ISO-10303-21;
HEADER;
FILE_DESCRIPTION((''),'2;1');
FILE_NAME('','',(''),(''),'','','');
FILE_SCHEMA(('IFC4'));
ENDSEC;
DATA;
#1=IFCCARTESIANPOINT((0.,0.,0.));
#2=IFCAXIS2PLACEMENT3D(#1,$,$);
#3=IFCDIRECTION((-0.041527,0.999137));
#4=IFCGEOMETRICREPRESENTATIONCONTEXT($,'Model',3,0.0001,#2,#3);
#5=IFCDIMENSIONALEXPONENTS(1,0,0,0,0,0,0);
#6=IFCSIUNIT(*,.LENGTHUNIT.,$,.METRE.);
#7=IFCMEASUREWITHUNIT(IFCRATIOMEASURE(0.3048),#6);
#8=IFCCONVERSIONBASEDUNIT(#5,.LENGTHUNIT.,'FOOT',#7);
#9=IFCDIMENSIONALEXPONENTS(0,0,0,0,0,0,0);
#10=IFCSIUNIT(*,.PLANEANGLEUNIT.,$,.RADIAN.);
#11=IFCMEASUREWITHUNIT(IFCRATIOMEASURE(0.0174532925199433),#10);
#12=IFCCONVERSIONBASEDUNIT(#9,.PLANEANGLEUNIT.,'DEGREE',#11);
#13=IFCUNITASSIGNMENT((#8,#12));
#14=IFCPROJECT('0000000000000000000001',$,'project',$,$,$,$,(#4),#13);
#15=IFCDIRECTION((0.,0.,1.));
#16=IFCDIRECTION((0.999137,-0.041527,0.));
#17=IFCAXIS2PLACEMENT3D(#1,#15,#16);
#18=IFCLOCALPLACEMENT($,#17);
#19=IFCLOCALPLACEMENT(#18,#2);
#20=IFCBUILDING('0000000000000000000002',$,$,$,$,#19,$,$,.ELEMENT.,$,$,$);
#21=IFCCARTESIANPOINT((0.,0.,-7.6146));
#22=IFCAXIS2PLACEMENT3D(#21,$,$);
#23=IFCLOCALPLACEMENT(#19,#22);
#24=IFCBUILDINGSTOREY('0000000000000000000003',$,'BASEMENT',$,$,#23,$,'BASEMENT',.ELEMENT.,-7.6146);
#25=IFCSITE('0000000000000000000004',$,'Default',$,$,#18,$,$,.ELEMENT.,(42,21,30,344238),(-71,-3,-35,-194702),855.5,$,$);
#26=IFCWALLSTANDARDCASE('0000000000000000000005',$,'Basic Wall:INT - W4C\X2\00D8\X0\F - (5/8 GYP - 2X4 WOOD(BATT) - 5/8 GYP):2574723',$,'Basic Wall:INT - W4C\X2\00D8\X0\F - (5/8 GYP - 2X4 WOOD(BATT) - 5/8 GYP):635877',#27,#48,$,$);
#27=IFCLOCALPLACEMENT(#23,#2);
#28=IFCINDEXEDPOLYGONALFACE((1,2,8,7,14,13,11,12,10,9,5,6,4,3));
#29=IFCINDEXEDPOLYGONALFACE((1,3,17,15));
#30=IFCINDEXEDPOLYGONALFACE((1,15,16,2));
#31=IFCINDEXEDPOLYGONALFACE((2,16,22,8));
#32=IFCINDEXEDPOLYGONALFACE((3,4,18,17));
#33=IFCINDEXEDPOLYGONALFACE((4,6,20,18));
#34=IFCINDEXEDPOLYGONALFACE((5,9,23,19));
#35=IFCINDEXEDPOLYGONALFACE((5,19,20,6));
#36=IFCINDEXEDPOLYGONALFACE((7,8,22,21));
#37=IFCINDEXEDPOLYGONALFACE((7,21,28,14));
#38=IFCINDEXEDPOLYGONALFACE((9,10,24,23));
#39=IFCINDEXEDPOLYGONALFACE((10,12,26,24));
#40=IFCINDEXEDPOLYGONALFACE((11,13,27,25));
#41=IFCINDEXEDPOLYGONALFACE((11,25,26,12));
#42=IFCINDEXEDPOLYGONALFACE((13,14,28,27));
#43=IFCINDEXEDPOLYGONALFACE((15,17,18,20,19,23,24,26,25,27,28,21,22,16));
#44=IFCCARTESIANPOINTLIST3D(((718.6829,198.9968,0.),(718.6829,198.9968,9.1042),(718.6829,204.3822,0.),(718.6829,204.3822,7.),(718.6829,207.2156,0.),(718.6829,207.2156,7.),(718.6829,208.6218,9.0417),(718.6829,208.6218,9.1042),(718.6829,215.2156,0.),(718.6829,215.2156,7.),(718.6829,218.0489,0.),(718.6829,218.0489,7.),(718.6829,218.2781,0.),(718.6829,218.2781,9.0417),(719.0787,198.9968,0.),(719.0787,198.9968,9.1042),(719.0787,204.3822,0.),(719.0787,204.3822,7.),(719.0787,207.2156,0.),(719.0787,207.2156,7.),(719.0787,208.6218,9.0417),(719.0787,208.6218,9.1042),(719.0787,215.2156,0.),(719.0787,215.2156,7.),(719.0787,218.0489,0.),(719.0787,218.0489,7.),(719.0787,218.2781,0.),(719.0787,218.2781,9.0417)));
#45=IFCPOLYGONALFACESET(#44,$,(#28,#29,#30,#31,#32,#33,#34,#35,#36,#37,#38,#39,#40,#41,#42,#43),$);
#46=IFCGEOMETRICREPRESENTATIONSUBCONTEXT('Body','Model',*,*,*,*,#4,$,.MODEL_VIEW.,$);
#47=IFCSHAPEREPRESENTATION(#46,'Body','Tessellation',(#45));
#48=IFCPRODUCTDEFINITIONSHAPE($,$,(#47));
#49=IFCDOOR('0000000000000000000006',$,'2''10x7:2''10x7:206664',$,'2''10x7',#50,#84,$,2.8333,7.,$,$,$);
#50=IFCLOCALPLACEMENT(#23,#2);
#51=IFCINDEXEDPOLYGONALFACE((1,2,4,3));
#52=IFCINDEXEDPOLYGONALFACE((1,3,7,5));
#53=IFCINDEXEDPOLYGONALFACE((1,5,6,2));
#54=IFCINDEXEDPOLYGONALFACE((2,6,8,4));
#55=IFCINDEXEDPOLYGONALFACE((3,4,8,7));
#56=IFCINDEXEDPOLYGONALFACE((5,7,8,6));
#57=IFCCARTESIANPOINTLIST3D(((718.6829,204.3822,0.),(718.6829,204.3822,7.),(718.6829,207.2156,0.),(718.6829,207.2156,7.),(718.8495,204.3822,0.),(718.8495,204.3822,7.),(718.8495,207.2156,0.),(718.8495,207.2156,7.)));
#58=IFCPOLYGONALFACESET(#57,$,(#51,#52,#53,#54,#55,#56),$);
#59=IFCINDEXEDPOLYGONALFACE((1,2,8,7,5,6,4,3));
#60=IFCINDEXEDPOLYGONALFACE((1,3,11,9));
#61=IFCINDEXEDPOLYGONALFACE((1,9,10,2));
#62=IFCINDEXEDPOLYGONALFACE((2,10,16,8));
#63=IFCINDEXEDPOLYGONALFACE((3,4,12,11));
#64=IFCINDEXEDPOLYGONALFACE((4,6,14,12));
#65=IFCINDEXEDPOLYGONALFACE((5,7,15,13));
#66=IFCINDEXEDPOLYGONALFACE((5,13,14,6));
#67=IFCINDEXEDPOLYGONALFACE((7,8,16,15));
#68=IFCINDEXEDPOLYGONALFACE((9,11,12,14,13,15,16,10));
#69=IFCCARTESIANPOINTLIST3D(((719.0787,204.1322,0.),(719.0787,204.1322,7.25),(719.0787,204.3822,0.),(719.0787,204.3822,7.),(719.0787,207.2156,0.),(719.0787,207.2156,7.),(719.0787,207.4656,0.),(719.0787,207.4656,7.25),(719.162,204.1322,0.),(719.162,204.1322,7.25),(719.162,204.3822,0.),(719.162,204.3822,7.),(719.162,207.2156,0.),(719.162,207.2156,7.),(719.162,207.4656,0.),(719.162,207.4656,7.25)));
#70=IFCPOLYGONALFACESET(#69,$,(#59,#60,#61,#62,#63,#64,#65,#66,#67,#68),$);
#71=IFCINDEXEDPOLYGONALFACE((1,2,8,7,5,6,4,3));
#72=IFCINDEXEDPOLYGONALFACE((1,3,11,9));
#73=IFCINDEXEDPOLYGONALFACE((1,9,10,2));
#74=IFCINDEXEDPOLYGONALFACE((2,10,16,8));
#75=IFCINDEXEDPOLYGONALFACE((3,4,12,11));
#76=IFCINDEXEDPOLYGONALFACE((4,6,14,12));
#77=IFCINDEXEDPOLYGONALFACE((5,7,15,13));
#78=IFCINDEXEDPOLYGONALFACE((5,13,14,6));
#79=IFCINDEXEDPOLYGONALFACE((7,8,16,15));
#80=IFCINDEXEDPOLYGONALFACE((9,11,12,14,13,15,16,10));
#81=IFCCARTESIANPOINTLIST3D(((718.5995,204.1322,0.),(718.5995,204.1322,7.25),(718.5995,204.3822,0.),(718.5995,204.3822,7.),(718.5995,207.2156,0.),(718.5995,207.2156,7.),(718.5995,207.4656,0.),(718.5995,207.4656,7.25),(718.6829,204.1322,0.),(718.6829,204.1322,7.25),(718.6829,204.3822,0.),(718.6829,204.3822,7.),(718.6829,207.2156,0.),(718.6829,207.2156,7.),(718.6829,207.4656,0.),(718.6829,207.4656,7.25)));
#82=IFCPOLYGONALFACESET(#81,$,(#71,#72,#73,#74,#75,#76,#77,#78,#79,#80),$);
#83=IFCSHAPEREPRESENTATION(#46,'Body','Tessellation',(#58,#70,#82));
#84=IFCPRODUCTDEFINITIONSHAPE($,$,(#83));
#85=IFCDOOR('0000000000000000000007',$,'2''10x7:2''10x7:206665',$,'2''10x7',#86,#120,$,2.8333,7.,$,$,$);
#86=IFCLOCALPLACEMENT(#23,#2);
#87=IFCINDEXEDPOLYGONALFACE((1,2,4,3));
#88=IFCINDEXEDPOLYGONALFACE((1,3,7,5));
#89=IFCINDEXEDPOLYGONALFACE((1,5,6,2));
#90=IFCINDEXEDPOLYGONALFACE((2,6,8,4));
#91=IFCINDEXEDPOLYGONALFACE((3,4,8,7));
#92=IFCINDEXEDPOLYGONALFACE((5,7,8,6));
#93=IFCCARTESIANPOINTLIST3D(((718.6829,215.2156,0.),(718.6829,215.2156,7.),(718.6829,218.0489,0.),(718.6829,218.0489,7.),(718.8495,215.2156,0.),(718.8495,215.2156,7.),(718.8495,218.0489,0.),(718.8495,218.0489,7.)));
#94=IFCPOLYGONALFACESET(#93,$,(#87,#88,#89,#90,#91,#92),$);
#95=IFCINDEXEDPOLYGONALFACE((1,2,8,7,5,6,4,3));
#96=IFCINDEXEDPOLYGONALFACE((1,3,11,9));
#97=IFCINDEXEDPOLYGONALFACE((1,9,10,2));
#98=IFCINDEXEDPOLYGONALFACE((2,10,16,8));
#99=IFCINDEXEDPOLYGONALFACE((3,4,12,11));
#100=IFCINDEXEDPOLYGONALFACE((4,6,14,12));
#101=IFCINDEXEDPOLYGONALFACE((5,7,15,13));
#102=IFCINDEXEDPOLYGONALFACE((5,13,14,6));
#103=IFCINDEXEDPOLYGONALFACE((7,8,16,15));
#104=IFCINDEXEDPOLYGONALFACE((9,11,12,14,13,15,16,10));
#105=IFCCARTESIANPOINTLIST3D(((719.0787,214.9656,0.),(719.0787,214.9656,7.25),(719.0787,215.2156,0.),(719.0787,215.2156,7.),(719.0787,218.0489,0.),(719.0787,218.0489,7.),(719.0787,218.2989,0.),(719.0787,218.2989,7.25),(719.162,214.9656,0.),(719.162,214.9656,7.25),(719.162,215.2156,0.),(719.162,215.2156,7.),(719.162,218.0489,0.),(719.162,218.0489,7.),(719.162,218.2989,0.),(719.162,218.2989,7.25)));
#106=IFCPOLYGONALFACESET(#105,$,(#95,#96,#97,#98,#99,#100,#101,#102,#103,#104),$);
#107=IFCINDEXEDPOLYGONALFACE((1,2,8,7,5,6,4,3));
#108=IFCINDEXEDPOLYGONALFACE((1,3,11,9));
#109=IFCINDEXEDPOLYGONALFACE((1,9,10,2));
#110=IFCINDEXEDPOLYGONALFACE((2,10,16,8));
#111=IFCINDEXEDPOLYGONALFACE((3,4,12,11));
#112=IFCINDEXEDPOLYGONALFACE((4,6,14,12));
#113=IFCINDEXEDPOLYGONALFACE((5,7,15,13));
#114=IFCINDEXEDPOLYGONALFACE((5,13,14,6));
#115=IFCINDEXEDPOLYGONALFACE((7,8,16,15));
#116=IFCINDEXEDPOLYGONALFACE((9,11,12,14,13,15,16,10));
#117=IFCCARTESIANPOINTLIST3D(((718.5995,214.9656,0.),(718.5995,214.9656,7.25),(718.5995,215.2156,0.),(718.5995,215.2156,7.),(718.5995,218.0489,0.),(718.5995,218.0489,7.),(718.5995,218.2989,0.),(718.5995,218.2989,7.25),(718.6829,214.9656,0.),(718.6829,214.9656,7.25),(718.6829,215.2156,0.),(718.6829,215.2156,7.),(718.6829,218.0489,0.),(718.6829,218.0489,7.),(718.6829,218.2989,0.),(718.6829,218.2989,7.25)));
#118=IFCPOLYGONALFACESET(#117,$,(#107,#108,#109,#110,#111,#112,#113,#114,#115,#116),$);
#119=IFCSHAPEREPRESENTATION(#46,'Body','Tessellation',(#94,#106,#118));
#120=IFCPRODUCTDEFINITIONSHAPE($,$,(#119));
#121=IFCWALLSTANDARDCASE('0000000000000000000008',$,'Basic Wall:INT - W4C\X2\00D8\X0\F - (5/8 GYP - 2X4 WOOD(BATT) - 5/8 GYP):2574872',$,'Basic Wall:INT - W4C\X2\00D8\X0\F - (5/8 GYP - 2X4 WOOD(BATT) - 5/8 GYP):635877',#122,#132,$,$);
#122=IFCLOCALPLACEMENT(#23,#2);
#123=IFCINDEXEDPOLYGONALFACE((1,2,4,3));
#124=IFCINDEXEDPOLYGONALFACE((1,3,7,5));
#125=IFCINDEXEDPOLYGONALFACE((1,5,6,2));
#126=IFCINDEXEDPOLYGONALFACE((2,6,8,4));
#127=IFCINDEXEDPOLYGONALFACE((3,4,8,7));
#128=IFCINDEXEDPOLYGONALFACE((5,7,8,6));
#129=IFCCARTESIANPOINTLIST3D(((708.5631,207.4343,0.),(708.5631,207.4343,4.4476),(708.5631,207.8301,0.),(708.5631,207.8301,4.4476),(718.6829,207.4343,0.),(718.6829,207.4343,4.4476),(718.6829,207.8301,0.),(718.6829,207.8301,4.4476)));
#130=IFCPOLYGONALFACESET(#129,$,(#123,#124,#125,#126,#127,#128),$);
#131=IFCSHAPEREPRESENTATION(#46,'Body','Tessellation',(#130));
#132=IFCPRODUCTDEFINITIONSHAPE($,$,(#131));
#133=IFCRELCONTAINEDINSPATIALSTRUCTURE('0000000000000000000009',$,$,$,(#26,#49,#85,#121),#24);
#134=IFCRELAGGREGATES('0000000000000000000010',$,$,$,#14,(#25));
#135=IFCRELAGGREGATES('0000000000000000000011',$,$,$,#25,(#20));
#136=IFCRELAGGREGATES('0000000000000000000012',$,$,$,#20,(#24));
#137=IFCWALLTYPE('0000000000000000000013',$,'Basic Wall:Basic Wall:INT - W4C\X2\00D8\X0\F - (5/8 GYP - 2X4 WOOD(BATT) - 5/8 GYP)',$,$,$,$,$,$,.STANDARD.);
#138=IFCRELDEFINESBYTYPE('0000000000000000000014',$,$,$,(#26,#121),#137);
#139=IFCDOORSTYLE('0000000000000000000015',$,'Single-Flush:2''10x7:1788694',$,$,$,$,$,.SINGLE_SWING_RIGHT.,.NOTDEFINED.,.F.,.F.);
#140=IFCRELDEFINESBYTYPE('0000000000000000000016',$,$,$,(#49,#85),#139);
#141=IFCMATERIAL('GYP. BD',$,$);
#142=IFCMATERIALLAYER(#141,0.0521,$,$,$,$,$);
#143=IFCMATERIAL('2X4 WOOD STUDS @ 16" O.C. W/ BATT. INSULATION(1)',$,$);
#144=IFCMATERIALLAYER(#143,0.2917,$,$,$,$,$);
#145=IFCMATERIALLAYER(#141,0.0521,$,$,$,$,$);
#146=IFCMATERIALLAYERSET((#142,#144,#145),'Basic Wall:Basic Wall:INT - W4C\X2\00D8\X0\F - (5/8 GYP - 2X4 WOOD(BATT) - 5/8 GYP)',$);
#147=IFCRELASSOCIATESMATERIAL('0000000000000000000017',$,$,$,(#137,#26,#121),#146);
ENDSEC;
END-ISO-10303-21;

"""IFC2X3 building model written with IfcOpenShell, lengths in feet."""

from ifc_helpers import new_model, entity, si_unit, converted_unit, direction, frame, frame_2d, origin, origin_2d_with_axis, place, context, subcontext, project, spatial, polyline, rectangle, outline, extrude, source, transform, mapped, material, layer, layer_set, layer_usage, type_object, type_shapes, element, fill, save


model = new_model("IFC2X3")

# Units and contexts
model_context = context("Model", 3, precision=0.0001, world=origin(), true_north=direction((-0.041527, 0.999137)))
body_context = subcontext(model_context, "Body", "Model", "MODEL_VIEW")
ifc_project = project(units=[converted_unit("LENGTHUNIT", "FOOT", entity("IfcRatioMeasure", 0.3048), si_unit("LENGTHUNIT", "METRE"), dimensions=[1, 0, 0, 0, 0, 0, 0]), converted_unit("PLANEANGLEUNIT", "DEGREE", entity("IfcRatioMeasure", 0.0174532925199433), si_unit("PLANEANGLEUNIT", "RADIAN"), dimensions=[0, 0, 0, 0, 0, 0, 0])], contexts=[model_context])

# Site, building, storey
site_placement = place(None, frame((0.0, 0.0, 0.0), z_axis=(0.0, 0.0, 1.0), x_axis=(0.999137, -0.041527, 0.0)))
site = spatial("IfcSite", under=ifc_project, at=site_placement, Name="Default", CompositionType="ELEMENT", RefLatitude=(42, 21, 30, 344238), RefLongitude=(-71, -3, -35, -194702), RefElevation=855.5)
building_placement = place(site_placement, origin())
building = spatial("IfcBuilding", under=site, at=building_placement, CompositionType="ELEMENT")
storey_placement = place(building_placement, frame((0.0, 0.0, -7.6146)))
storey = spatial("IfcBuildingStorey", under=building, at=storey_placement, Name="BASEMENT", LongName="BASEMENT", CompositionType="ELEMENT", Elevation=-7.6146)

# Shared definitions
ifc_material_1 = material(Name="GYP. BD")

# Shared definitions
ifc_layer_1 = layer(ifc_material_1, 0.0521)
ifc_material_2 = material(Name="2X4 WOOD STUDS @ 16\" O.C. W/ BATT. INSULATION(1)")
ifc_layer_2 = layer(ifc_material_2, 0.2917)
ifc_layer_3 = layer(ifc_material_1, 0.0521)
ifc_layer_set_1 = layer_set([ifc_layer_1, ifc_layer_2, ifc_layer_3], Name="Basic Wall:Basic Wall:INT - W4CØF - (5/8 GYP - 2X4 WOOD(BATT) - 5/8 GYP)")
wall_type_1 = type_object("IfcWallType", Name="Basic Wall:Basic Wall:INT - W4CØF - (5/8 GYP - 2X4 WOOD(BATT) - 5/8 GYP)", PredefinedType="STANDARD", material=ifc_layer_set_1)

# Wall, openings, doors
ifc_layer_usage_1 = layer_usage(ifc_layer_set_1, "AXIS2", "NEGATIVE", 0.1979)
wall_1_placement = place(storey_placement, frame((718.8808, 198.9968, 0.0), z_axis=(0.0, 0.0, 1.0), x_axis=(0.0, 1.0, 0.0)))
wall_1 = element("IfcWallStandardCase", 1, at=wall_1_placement, inside=storey, type_object=wall_type_1, material=ifc_layer_usage_1, Name="Basic Wall:INT - W4CØF - (5/8 GYP - 2X4 WOOD(BATT) - 5/8 GYP):2574723", ObjectType="Basic Wall:INT - W4CØF - (5/8 GYP - 2X4 WOOD(BATT) - 5/8 GYP):635877", context=body_context, shape_type="SweptSolid", body=[
    extrude(rectangle(XDim=19.2813, YDim=0.3958, at=frame_2d((9.6406, 0.0), x_axis=(-1.0, 0.0))), origin(), (0.0, 0.0, 1.0), 9.1042),
])
opening_1_placement = place(wall_1_placement, origin())
element("IfcOpeningElement", 2, at=opening_1_placement, cuts=wall_1, ObjectType="Opening", context=body_context, shape_type="SweptSolid", body=[
    extrude(rectangle(XDim=0.0625, YDim=9.6563, at=origin_2d_with_axis()), frame((14.4531, 0.1979, 9.0729), z_axis=(0.0, -1.0, 0.0), x_axis=(0.0, 0.0, 1.0)), (0.0, 0.0, 1.0), 0.3958),
])
opening_2_placement = place(wall_1_placement, frame((-198.9968, 718.8808, 0.0), z_axis=(0.0, 0.0, 1.0), x_axis=(0.0, -1.0, 0.0)))
opening_2 = element("IfcOpeningElement", 3, at=opening_2_placement, cuts=wall_1, ObjectType="Opening", context=body_context, shape_type="SweptSolid", body=[
    extrude(rectangle(XDim=7.0, YDim=2.8333, at=frame_2d((0.0, 0.0), x_axis=(1.0, 0.0))), frame((719.0827, 205.7989, 3.5), z_axis=(-1.0, 0.0, 0.0), x_axis=(0.0, 0.0, -1.0)), (0.0, 0.0, 1.0), 0.4037),
])
opening_3_placement = place(wall_1_placement, frame((-198.9968, 718.8808, 0.0), z_axis=(0.0, 0.0, 1.0), x_axis=(0.0, -1.0, 0.0)))
opening_3 = element("IfcOpeningElement", 4, at=opening_3_placement, cuts=wall_1, ObjectType="Opening", context=body_context, shape_type="SweptSolid", body=[
    extrude(rectangle(XDim=7.0, YDim=2.8333, at=frame_2d((0.0, 0.0), x_axis=(1.0, 0.0))), frame((719.0827, 216.6322, 3.5), z_axis=(-1.0, 0.0, 0.0), x_axis=(0.0, 0.0, -1.0)), (0.0, 0.0, 1.0), 0.4037),
])
door_style_1 = type_object("IfcDoorStyle", Name="Single-Flush:2'10x7:1788694", ConstructionType="NOTDEFINED", OperationType="SINGLE_SWING_RIGHT", ParameterTakesPrecedence=False, Sizeable=False)
shared_shape_1 = source(origin(), body_context, "Body", "SweptSolid", [
    extrude(rectangle(XDim=2.8333, YDim=0.1667, at=frame_2d((0.0, 0.0), x_axis=(1.0, 0.0))), frame((1.4167, -0.0873, 0.0), z_axis=(0.0, 0.0, 1.0), x_axis=(-1.0, 0.0, 0.0)), (0.0, 0.0, 1.0), 7.0),
    extrude(outline(polyline([(-1.6667, -3.5625), (-1.4167, -3.5625), (-1.4167, 3.4375), (1.4167, 3.4375), (1.4167, -3.5625), (1.6667, -3.5625), (1.6667, 3.6875), (-1.6667, 3.6875), (-1.6667, -3.5625)])), frame((1.4167, -0.4831, 3.5625), z_axis=(0.0, 1.0, 0.0), x_axis=(-1.0, 0.0, 0.0)), (0.0, 0.0, 1.0), 0.0833),
    extrude(outline(polyline([(-3.6875, -1.6667), (3.5625, -1.6667), (3.5625, -1.4167), (-3.4375, -1.4167), (-3.4375, 1.4167), (3.5625, 1.4167), (3.5625, 1.6667), (-3.6875, 1.6667), (-3.6875, -1.6667)])), frame((1.4167, -0.004, 3.5625), z_axis=(0.0, 1.0, 0.0), x_axis=(0.0, 0.0, -1.0)), (0.0, 0.0, 1.0), 0.0833),
])
type_shapes(door_style_1, [shared_shape_1])
door_1_placement = place(opening_2_placement, frame((718.6789, 204.3822, 0.0), z_axis=(0.0, 0.0, 1.0), x_axis=(0.0, 1.0, 0.0)))
door_1 = element("IfcDoor", 5, at=door_1_placement, inside=storey, type_object=door_style_1, Name="2'10x7:2'10x7:206664", ObjectType="2'10x7", OverallHeight=2.8333, OverallWidth=7.0, context=body_context, shape_type="MappedRepresentation", body=[
    mapped(shared_shape_1, transform((0.0, 0.0, 0.0), scale=1.0)),
])
fill(opening_2, door_1)
door_2_placement = place(opening_3_placement, frame((718.6789, 215.2156, 0.0), z_axis=(0.0, 0.0, 1.0), x_axis=(0.0, 1.0, 0.0)))
door_2 = element("IfcDoor", 6, at=door_2_placement, inside=storey, type_object=door_style_1, Name="2'10x7:2'10x7:206665", ObjectType="2'10x7", OverallHeight=2.8333, OverallWidth=7.0, context=body_context, shape_type="MappedRepresentation", body=[
    mapped(shared_shape_1, transform((0.0, 0.0, 0.0), scale=1.0)),
])
fill(opening_3, door_2)

# Wall
ifc_layer_usage_2 = layer_usage(ifc_layer_set_1, "AXIS2", "NEGATIVE", 0.1979)
wall_2_placement = place(storey_placement, frame((718.6829, 207.6322, 0.0), z_axis=(0.0, 0.0, 1.0), x_axis=(-1.0, 0.0, 0.0)))
element("IfcWallStandardCase", 7, at=wall_2_placement, inside=storey, type_object=wall_type_1, material=ifc_layer_usage_2, Name="Basic Wall:INT - W4CØF - (5/8 GYP - 2X4 WOOD(BATT) - 5/8 GYP):2574872", ObjectType="Basic Wall:INT - W4CØF - (5/8 GYP - 2X4 WOOD(BATT) - 5/8 GYP):635877", context=body_context, shape_type="SweptSolid", body=[
    extrude(rectangle(XDim=10.1198, YDim=0.3958, at=frame_2d((5.0599, 0.0), x_axis=(-1.0, 0.0))), origin(), (0.0, 0.0, 1.0), 4.4476),
])

save(model, "model.ifc")
